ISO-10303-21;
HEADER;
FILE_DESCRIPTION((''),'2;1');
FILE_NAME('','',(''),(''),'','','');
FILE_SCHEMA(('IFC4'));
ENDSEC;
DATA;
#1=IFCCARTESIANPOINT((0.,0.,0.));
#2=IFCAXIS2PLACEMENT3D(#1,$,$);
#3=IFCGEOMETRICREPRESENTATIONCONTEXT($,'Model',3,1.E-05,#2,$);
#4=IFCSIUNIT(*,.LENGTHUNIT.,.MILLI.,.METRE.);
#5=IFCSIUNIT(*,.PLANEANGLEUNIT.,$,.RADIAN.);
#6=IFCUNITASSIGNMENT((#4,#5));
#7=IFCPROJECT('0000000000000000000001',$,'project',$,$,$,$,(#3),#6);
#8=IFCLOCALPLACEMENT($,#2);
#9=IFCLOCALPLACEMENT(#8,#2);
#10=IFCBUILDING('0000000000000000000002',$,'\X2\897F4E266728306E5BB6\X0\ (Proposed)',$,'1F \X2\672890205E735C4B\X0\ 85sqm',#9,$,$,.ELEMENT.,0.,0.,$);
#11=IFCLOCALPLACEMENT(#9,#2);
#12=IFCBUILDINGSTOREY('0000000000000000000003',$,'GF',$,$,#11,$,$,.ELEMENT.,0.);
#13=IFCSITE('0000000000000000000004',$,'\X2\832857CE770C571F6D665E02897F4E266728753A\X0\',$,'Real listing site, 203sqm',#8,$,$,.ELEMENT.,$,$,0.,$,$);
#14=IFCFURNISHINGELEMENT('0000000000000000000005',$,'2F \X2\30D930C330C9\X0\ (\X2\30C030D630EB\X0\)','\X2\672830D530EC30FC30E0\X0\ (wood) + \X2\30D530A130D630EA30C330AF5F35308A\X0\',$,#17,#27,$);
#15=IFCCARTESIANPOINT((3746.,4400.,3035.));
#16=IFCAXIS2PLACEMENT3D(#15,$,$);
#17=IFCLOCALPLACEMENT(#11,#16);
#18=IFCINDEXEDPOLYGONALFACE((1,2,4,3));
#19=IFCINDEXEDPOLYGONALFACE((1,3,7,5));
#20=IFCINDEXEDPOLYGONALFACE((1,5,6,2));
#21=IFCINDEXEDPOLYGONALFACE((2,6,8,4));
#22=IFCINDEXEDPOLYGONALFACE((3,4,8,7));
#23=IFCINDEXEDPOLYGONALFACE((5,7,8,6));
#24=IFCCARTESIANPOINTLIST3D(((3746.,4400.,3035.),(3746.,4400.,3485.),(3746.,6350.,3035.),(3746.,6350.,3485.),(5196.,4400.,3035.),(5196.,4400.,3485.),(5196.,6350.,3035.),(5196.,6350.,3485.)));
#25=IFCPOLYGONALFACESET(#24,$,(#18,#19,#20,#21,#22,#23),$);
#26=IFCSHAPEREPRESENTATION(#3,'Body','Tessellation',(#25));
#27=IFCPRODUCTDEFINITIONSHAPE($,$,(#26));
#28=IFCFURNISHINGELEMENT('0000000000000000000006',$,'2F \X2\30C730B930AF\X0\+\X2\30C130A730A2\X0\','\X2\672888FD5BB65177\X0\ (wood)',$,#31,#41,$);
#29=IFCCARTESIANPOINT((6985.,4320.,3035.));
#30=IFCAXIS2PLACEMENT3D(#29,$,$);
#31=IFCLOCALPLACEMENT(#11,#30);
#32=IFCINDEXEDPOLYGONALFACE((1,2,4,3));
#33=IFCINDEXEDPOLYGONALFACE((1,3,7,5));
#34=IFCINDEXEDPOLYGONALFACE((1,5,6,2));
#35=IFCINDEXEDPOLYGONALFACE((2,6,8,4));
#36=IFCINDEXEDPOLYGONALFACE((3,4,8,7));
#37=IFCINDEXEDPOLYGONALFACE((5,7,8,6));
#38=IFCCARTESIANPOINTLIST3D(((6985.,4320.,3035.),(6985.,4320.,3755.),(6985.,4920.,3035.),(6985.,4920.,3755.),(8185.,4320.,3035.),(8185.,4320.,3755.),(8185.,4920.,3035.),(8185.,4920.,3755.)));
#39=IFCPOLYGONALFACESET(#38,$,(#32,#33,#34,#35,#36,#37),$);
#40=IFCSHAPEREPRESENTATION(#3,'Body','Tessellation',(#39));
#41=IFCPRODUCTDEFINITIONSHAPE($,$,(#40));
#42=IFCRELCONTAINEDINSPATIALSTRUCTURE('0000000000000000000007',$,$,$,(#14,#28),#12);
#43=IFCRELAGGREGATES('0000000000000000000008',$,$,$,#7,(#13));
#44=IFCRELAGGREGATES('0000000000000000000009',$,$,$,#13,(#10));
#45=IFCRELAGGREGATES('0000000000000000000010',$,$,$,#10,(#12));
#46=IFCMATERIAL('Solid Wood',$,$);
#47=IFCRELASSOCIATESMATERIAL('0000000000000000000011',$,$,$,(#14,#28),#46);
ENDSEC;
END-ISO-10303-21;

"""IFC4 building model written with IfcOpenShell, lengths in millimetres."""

from ifc_helpers import new_model, si_unit, frame, frame_2d, origin, place, context, project, spatial, rectangle, extrude, material, element, save


model = new_model("IFC4")

# Units and contexts
model_context = context("Model", 3, precision=1e-05, world=origin())
ifc_project = project(units=[si_unit("LENGTHUNIT", "METRE", prefix="MILLI"), si_unit("PLANEANGLEUNIT", "RADIAN")], contexts=[model_context])

# Site, building, storey
site_placement = place(None, origin())
site = spatial("IfcSite", under=ifc_project, at=site_placement, Name="茨城県土浦市西並木町", ObjectType="Real listing site, 203sqm", CompositionType="ELEMENT", RefElevation=0.0)
building_placement = place(site_placement, origin())
building = spatial("IfcBuilding", under=site, at=building_placement, Name="西並木の家 (Proposed)", ObjectType="1F 木造平屋 85sqm", CompositionType="ELEMENT", ElevationOfRefHeight=0.0, ElevationOfTerrain=0.0)
storey_placement = place(building_placement, origin())
storey = spatial("IfcBuildingStorey", under=building, at=storey_placement, Name="GF", CompositionType="ELEMENT", Elevation=0.0)

# Shared definitions
ifc_material_1 = material(Name="Solid Wood")

# Furnishing elements
furnishing_1_placement = place(storey_placement, frame((3746.0, 4400.0, 3035.0)))
element("IfcFurnishingElement", 1, at=furnishing_1_placement, inside=storey, material=ifc_material_1, Name="2F ベッド (ダブル)", Description="木フレーム (wood) + ファブリック張り", context=model_context, shape_type="SweptSolid", body=[
    extrude(rectangle(XDim=1450.0, YDim=1950.0, at=frame_2d((725.0, 975.0))), frame((3746.0, 4400.0, 3035.0)), (0.0, 0.0, 1.0), 450.0),
])
furnishing_2_placement = place(storey_placement, frame((6985.0, 4320.0, 3035.0)))
element("IfcFurnishingElement", 2, at=furnishing_2_placement, inside=storey, material=ifc_material_1, Name="2F デスク+チェア", Description="木製家具 (wood)", context=model_context, shape_type="SweptSolid", body=[
    extrude(rectangle(XDim=1200.0, YDim=600.0, at=frame_2d((600.0, 300.0))), frame((6985.0, 4320.0, 3035.0)), (0.0, 0.0, 1.0), 720.0),
])

save(model, "model.ifc")
